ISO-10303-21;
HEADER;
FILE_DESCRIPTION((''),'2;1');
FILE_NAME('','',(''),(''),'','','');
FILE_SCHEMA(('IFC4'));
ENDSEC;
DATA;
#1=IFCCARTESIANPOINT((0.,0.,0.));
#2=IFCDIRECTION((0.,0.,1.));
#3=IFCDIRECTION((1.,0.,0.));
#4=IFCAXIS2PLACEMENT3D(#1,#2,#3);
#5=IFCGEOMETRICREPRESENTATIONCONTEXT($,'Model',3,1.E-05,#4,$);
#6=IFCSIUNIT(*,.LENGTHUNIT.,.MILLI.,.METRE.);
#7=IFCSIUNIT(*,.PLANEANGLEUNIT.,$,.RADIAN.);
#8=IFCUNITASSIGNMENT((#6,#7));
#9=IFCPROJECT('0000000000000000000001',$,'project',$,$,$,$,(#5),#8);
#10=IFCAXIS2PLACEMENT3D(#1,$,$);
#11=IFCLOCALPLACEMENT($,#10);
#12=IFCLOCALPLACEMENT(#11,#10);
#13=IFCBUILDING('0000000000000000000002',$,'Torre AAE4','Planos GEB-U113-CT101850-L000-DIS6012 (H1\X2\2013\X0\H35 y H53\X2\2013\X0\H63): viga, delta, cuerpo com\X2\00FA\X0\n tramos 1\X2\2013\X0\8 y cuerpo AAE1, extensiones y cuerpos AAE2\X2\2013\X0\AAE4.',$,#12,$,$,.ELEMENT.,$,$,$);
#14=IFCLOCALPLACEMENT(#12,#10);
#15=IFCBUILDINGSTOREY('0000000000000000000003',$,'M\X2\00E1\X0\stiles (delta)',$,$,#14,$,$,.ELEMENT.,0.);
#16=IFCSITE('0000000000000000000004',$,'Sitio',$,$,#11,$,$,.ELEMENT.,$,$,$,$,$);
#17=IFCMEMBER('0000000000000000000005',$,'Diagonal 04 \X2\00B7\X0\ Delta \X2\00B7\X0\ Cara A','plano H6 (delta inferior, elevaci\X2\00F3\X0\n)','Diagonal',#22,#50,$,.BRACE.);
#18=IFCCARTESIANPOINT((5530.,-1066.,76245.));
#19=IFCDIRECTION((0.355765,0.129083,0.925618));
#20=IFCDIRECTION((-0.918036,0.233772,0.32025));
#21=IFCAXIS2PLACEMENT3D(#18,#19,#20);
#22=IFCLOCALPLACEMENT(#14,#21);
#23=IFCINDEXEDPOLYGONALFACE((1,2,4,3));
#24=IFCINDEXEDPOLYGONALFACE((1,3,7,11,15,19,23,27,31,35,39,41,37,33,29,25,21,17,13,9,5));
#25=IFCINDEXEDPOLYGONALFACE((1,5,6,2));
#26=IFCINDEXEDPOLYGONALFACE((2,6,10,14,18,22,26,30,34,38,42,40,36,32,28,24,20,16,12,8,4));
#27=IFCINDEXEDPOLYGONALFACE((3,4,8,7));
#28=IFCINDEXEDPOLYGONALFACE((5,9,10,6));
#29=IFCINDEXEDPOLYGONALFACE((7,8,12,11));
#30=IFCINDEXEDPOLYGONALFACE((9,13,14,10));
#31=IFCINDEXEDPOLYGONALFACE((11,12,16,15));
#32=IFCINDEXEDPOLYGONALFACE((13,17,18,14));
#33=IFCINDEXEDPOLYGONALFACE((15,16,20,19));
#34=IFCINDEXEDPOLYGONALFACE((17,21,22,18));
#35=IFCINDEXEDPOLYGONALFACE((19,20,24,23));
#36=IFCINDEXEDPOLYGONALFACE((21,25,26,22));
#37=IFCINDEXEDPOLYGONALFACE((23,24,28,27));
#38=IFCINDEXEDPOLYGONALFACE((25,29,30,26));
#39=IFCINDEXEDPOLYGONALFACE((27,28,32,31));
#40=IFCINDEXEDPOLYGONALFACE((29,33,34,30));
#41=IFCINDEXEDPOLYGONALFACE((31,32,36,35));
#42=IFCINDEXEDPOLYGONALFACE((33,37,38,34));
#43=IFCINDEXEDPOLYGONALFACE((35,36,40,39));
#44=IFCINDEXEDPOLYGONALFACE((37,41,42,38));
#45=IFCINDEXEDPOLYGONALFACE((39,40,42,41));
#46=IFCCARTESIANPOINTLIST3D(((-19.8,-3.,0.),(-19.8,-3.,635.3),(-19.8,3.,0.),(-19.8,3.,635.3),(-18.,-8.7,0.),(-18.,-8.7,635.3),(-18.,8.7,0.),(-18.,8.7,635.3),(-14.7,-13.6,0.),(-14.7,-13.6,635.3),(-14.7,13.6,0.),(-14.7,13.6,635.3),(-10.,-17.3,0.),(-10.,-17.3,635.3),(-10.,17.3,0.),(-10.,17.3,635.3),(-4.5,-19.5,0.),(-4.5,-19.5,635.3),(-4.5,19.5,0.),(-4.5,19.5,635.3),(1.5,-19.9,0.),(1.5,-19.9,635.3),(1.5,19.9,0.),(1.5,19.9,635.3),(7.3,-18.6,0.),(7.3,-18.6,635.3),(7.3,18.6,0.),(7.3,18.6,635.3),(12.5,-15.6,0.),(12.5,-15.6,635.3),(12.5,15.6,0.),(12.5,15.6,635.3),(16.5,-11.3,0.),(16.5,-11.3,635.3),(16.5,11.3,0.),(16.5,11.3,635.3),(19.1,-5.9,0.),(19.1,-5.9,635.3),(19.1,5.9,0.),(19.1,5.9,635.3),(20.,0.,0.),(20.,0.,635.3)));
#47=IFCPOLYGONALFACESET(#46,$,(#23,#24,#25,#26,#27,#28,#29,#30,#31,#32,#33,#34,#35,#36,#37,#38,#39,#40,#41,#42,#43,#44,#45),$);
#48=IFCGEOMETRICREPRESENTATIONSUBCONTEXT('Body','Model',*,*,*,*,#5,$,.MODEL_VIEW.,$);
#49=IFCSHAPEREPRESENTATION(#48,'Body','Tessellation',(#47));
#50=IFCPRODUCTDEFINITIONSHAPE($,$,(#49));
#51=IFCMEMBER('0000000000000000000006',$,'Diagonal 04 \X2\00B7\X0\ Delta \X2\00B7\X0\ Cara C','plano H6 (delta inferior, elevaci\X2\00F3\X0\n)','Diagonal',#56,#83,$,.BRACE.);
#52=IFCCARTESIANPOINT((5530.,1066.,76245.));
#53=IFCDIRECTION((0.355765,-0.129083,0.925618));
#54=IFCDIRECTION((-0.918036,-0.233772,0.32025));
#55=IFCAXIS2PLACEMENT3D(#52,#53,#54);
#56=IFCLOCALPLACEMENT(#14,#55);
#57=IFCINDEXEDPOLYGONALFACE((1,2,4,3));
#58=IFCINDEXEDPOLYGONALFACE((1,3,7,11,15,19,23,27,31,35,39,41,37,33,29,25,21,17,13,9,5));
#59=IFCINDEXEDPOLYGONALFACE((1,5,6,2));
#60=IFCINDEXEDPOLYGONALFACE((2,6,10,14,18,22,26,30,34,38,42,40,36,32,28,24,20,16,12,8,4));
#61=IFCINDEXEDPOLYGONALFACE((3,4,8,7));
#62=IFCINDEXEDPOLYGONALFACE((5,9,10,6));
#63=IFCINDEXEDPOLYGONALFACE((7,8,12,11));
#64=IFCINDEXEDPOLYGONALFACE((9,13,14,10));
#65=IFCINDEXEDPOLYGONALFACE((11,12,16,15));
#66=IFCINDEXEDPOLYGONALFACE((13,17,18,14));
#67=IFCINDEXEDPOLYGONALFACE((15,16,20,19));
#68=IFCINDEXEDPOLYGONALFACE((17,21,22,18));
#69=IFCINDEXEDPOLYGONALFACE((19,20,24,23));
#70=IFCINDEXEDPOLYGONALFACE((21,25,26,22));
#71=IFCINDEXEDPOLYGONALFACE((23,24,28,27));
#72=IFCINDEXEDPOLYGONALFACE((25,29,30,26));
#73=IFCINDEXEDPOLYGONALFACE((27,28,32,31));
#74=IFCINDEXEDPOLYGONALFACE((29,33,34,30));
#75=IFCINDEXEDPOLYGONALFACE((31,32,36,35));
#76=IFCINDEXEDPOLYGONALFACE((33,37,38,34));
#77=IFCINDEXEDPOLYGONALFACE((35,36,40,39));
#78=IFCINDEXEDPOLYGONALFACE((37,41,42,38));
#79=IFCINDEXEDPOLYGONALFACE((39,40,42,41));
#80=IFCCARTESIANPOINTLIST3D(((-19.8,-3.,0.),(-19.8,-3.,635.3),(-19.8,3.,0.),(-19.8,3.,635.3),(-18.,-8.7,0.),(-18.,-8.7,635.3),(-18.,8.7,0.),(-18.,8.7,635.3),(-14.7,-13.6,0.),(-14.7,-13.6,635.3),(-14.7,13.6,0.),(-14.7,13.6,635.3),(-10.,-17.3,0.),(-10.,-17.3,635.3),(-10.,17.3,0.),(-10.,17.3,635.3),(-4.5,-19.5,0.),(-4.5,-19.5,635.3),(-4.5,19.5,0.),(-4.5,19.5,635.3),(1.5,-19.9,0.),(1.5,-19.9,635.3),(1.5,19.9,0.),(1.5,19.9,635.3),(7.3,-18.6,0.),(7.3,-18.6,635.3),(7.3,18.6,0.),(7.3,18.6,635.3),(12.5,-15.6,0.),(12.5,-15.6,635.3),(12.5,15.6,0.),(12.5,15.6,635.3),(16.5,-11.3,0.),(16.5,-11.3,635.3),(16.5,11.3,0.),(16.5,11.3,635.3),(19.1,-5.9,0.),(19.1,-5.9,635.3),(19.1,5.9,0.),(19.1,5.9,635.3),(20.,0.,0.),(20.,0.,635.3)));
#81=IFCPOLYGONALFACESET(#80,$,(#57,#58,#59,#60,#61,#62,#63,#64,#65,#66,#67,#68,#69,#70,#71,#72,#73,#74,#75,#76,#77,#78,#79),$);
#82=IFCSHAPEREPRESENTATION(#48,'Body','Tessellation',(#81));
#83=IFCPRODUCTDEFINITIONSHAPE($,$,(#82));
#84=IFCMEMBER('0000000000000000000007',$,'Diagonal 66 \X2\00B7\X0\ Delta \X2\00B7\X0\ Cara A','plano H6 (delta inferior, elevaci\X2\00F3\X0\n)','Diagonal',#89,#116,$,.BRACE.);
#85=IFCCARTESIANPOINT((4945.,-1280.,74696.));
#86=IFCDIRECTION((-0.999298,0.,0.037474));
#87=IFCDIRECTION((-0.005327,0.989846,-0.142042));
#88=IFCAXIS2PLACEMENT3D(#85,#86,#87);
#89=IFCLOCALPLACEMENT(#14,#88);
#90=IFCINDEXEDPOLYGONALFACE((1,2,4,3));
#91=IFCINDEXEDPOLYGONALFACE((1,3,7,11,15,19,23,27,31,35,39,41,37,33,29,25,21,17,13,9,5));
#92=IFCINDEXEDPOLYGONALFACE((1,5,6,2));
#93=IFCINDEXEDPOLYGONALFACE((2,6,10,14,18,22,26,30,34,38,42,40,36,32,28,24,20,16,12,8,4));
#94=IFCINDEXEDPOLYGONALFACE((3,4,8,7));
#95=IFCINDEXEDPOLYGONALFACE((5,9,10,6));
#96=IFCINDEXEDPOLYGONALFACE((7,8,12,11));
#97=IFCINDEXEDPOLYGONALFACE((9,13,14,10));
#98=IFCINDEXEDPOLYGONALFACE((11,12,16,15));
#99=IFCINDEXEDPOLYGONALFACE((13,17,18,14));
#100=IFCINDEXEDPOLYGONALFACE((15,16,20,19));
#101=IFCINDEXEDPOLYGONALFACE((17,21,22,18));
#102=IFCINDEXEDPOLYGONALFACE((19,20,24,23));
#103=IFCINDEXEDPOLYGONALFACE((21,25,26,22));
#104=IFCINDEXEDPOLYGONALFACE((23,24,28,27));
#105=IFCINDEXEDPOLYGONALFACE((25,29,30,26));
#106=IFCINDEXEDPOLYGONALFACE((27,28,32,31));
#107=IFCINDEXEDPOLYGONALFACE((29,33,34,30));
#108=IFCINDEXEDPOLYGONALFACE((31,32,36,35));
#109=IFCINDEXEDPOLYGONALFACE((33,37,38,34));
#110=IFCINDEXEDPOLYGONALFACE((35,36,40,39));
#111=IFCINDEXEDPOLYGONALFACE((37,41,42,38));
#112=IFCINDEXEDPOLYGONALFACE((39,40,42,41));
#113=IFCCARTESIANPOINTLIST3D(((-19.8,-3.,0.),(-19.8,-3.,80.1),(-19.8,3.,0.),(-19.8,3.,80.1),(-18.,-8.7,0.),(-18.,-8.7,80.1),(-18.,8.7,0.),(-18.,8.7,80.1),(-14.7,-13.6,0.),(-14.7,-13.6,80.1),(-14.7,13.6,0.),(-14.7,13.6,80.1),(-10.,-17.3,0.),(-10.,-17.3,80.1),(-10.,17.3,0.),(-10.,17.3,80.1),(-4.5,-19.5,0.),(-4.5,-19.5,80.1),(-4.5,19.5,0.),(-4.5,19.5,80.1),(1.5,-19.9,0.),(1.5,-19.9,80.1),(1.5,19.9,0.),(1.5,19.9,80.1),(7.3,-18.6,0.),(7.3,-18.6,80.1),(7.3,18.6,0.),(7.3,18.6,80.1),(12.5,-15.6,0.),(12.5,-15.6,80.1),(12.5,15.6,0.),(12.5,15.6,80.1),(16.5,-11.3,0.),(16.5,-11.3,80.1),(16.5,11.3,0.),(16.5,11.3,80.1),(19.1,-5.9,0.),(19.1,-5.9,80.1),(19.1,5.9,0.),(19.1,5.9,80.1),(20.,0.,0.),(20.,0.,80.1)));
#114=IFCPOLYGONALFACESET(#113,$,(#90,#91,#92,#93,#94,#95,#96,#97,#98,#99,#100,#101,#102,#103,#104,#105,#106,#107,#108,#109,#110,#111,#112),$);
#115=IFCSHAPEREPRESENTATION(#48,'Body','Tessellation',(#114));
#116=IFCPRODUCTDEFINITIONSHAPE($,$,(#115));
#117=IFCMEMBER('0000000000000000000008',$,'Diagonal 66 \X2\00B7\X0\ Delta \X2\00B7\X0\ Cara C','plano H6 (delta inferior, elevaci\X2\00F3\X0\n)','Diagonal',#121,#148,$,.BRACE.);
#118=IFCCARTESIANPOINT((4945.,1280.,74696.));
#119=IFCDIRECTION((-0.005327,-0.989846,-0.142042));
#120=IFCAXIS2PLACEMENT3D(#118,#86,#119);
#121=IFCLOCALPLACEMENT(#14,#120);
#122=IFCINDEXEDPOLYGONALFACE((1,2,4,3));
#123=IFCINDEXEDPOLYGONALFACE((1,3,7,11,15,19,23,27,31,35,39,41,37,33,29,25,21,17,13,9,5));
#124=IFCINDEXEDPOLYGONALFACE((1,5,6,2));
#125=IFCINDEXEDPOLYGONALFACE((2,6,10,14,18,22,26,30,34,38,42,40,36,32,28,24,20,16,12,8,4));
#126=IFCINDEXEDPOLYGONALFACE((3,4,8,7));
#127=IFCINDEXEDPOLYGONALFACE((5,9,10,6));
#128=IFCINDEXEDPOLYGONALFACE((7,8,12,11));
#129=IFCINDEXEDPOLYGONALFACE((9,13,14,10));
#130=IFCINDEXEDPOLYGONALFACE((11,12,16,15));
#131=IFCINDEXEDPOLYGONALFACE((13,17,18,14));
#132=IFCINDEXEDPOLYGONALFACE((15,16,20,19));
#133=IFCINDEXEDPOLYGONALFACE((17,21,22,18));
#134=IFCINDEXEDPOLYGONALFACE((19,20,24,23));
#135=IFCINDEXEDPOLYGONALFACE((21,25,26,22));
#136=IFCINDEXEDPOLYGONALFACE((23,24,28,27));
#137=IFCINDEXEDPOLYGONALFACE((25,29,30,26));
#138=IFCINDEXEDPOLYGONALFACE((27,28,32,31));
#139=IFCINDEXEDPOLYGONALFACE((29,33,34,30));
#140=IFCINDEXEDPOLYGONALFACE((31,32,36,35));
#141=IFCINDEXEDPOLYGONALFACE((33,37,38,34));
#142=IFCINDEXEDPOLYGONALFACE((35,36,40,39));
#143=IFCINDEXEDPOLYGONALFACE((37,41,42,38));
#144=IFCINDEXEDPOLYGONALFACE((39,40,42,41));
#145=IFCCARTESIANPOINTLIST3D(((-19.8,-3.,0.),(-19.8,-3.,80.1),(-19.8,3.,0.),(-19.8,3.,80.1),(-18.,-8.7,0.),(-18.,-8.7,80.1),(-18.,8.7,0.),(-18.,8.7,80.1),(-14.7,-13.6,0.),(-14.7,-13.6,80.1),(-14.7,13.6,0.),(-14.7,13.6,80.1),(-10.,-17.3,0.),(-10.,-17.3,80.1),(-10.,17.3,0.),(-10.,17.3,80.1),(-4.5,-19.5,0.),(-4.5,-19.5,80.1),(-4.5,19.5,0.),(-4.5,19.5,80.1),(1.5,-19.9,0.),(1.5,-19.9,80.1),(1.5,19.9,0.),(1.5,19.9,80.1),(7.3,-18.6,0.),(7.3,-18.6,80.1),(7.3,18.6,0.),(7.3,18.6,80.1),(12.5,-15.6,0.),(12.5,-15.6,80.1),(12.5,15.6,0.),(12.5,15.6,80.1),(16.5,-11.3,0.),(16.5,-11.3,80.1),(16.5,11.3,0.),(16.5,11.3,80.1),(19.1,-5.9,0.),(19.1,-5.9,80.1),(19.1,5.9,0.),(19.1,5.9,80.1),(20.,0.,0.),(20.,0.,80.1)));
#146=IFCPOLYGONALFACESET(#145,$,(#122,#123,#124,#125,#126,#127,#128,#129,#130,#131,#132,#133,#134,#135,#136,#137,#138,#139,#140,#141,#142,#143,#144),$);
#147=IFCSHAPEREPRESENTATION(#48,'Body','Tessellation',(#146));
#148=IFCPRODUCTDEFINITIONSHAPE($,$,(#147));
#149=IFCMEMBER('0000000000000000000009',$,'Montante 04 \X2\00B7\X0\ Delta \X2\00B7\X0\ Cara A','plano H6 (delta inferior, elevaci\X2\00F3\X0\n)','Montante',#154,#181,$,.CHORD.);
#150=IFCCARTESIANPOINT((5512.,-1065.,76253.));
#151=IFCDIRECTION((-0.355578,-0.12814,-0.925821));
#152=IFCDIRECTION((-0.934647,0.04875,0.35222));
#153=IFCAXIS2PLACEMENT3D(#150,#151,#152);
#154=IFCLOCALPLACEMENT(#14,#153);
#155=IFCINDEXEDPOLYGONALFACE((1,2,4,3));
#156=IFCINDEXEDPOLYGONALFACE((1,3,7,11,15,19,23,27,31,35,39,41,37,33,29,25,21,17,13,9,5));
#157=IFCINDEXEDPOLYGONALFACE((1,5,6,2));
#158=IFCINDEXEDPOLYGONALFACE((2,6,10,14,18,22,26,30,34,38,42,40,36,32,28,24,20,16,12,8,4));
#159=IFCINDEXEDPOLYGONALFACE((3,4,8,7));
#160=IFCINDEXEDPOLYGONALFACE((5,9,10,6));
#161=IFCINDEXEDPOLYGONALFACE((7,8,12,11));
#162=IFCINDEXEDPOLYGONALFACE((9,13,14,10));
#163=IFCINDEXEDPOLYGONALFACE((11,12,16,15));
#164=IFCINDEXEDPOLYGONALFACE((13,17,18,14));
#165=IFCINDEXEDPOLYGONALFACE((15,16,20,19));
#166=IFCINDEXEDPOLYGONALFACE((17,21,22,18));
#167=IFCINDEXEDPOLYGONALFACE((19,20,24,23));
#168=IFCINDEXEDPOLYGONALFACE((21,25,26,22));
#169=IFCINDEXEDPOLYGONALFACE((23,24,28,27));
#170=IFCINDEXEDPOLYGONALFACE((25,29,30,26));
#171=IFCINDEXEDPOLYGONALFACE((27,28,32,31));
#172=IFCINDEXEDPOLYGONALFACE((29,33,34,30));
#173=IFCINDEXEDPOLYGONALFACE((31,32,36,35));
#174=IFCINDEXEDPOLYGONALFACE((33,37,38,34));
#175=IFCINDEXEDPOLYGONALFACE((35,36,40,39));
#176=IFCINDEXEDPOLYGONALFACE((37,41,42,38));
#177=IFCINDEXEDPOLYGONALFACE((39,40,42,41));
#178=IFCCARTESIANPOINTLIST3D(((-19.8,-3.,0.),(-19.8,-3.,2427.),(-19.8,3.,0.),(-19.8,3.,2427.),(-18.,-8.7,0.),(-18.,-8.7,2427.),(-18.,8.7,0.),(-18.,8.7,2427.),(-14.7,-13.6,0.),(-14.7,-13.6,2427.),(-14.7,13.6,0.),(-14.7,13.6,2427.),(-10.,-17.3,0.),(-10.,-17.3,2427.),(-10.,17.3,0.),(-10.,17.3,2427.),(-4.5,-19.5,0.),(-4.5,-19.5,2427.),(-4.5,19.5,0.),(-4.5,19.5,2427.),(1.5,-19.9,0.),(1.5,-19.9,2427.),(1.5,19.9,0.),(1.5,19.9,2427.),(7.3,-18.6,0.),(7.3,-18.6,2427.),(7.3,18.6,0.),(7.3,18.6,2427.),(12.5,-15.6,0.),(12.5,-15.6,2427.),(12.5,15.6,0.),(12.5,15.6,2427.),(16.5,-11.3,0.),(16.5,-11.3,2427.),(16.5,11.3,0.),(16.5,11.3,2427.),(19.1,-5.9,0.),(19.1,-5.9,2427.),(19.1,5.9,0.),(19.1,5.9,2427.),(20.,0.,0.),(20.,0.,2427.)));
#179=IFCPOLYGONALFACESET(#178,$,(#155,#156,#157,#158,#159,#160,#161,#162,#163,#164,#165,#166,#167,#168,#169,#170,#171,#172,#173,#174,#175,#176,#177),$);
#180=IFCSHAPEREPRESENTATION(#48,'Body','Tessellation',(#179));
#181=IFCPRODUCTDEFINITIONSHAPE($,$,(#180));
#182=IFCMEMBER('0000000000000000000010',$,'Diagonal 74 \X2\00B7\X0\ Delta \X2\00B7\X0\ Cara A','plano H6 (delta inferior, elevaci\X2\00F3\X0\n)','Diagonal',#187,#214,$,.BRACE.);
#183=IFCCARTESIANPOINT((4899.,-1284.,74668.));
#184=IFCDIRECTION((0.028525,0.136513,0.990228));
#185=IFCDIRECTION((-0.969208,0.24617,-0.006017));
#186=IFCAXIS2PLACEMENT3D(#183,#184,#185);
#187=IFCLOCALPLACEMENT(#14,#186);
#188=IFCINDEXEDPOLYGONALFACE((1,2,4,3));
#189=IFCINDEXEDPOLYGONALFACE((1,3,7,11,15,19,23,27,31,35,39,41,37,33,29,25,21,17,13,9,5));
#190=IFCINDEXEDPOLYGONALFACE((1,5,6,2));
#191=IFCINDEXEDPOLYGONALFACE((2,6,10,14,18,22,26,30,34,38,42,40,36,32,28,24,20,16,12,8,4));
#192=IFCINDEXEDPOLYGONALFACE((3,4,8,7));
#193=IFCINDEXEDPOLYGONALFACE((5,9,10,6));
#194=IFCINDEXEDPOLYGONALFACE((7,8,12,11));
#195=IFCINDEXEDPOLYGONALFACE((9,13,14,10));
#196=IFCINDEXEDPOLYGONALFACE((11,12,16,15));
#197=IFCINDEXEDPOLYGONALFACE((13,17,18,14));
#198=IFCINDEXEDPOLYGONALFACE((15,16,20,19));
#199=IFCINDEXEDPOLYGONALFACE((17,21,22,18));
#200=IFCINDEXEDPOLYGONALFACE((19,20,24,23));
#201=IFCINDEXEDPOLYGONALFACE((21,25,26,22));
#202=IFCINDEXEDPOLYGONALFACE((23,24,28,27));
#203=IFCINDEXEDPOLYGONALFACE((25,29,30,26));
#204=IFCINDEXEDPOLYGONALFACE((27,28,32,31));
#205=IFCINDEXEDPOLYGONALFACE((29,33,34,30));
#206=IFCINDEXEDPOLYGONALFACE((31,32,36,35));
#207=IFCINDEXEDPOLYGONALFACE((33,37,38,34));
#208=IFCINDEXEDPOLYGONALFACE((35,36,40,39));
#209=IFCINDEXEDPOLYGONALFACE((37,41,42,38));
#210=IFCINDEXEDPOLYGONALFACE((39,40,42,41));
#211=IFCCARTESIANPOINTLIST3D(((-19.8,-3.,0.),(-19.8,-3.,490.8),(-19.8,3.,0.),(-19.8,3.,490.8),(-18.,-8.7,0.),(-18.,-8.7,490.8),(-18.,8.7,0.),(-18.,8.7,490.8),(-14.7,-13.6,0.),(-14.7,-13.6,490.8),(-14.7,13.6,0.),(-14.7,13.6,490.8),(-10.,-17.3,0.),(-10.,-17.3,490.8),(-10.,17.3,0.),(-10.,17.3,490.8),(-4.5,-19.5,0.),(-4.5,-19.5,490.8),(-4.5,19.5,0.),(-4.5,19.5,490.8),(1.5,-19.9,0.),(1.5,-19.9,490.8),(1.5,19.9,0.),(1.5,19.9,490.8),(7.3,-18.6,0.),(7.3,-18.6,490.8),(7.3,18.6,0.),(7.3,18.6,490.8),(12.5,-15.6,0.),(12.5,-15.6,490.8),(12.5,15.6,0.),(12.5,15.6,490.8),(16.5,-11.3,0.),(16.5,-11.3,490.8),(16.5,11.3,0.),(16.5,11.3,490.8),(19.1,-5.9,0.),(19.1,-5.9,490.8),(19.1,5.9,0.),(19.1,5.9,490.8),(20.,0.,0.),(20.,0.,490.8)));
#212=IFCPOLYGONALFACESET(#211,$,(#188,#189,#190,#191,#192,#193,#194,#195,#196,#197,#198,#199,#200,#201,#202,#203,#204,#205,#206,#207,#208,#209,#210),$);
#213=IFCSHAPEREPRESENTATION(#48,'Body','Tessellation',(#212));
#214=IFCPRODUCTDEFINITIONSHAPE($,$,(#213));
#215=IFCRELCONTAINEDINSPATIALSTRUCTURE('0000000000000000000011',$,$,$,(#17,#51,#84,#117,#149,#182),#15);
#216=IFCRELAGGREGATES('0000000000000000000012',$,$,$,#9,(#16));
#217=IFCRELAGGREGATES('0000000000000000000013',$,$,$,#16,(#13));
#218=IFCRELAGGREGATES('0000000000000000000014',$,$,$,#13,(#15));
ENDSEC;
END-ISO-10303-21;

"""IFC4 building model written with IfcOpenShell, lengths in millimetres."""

from ifc_helpers import new_model, si_unit, frame, origin, origin_with_axes, place, context, subcontext, project, spatial, circle, extrude, element, save


model = new_model("IFC4")

# Units and contexts
model_context = context("Model", 3, precision=1e-05, world=origin_with_axes())
body_context = subcontext(model_context, "Body", "Model", "MODEL_VIEW")
ifc_project = project(units=[si_unit("LENGTHUNIT", "METRE", prefix="MILLI"), si_unit("PLANEANGLEUNIT", "RADIAN")], contexts=[model_context])

# Site, building, storey
site_placement = place(None, origin())
site = spatial("IfcSite", under=ifc_project, at=site_placement, Name="Sitio", CompositionType="ELEMENT")
building_placement = place(site_placement, origin())
building = spatial("IfcBuilding", under=site, at=building_placement, Name="Torre AAE4", Description="Planos GEB-U113-CT101850-L000-DIS6012 (H1–H35 y H53–H63): viga, delta, cuerpo común tramos 1–8 y cuerpo AAE1, extensiones y cuerpos AAE2–AAE4.", CompositionType="ELEMENT")
storey_placement = place(building_placement, origin())
storey = spatial("IfcBuildingStorey", under=building, at=storey_placement, Name="Mástiles (delta)", CompositionType="ELEMENT", Elevation=0.0)

# Members
for number, where, z_axis, x_axis, name in (
    (1, (5530.0, -1066.0, 76245.0), (0.355765, 0.129083, 0.925618), (-0.918036, 0.233772, 0.32025), "Diagonal 04 · Delta · Cara A"),
    (2, (5530.0, 1066.0, 76245.0), (0.355765, -0.129083, 0.925618), (-0.918036, -0.233772, 0.32025), "Diagonal 04 · Delta · Cara C"),
):
    element("IfcMember", number, at=place(storey_placement, frame(where, z_axis=z_axis, x_axis=x_axis)), inside=storey, Name=name, Description="plano H6 (delta inferior, elevación)", ObjectType="Diagonal", PredefinedType="BRACE", context=body_context, shape_type="SweptSolid", body=[
        extrude(circle(Radius=20.0), None, (0.0, 0.0, 1.0), 635.3),
    ])
for number, where, z_axis, x_axis, name in (
    (3, (4945.0, -1280.0, 74696.0), (-0.999298, 0.0, 0.037474), (-0.005327, 0.989846, -0.142042), "Diagonal 66 · Delta · Cara A"),
    (4, (4945.0, 1280.0, 74696.0), (-0.999298, 0.0, 0.037474), (-0.005327, -0.989846, -0.142042), "Diagonal 66 · Delta · Cara C"),
):
    element("IfcMember", number, at=place(storey_placement, frame(where, z_axis=z_axis, x_axis=x_axis)), inside=storey, Name=name, Description="plano H6 (delta inferior, elevación)", ObjectType="Diagonal", PredefinedType="BRACE", context=body_context, shape_type="SweptSolid", body=[
        extrude(circle(Radius=20.0), None, (0.0, 0.0, 1.0), 80.1),
    ])
for number, where, z_axis, x_axis, name in (
    (5, (5512.0, -1065.0, 76253.0), (-0.355578, -0.12814, -0.925821), (-0.934647, 0.04875, 0.35222), "Montante 04 · Delta · Cara A"),
):
    element("IfcMember", number, at=place(storey_placement, frame(where, z_axis=z_axis, x_axis=x_axis)), inside=storey, Name=name, Description="plano H6 (delta inferior, elevación)", ObjectType="Montante", PredefinedType="CHORD", context=body_context, shape_type="SweptSolid", body=[
        extrude(circle(Radius=20.0), None, (0.0, 0.0, 1.0), 2427.0),
    ])
for number, where, z_axis, x_axis, name in (
    (6, (4899.0, -1284.0, 74668.0), (0.028525, 0.136513, 0.990228), (-0.969208, 0.24617, -0.006017), "Diagonal 74 · Delta · Cara A"),
):
    element("IfcMember", number, at=place(storey_placement, frame(where, z_axis=z_axis, x_axis=x_axis)), inside=storey, Name=name, Description="plano H6 (delta inferior, elevación)", ObjectType="Diagonal", PredefinedType="BRACE", context=body_context, shape_type="SweptSolid", body=[
        extrude(circle(Radius=20.0), None, (0.0, 0.0, 1.0), 490.8),
    ])

save(model, "model.ifc")
